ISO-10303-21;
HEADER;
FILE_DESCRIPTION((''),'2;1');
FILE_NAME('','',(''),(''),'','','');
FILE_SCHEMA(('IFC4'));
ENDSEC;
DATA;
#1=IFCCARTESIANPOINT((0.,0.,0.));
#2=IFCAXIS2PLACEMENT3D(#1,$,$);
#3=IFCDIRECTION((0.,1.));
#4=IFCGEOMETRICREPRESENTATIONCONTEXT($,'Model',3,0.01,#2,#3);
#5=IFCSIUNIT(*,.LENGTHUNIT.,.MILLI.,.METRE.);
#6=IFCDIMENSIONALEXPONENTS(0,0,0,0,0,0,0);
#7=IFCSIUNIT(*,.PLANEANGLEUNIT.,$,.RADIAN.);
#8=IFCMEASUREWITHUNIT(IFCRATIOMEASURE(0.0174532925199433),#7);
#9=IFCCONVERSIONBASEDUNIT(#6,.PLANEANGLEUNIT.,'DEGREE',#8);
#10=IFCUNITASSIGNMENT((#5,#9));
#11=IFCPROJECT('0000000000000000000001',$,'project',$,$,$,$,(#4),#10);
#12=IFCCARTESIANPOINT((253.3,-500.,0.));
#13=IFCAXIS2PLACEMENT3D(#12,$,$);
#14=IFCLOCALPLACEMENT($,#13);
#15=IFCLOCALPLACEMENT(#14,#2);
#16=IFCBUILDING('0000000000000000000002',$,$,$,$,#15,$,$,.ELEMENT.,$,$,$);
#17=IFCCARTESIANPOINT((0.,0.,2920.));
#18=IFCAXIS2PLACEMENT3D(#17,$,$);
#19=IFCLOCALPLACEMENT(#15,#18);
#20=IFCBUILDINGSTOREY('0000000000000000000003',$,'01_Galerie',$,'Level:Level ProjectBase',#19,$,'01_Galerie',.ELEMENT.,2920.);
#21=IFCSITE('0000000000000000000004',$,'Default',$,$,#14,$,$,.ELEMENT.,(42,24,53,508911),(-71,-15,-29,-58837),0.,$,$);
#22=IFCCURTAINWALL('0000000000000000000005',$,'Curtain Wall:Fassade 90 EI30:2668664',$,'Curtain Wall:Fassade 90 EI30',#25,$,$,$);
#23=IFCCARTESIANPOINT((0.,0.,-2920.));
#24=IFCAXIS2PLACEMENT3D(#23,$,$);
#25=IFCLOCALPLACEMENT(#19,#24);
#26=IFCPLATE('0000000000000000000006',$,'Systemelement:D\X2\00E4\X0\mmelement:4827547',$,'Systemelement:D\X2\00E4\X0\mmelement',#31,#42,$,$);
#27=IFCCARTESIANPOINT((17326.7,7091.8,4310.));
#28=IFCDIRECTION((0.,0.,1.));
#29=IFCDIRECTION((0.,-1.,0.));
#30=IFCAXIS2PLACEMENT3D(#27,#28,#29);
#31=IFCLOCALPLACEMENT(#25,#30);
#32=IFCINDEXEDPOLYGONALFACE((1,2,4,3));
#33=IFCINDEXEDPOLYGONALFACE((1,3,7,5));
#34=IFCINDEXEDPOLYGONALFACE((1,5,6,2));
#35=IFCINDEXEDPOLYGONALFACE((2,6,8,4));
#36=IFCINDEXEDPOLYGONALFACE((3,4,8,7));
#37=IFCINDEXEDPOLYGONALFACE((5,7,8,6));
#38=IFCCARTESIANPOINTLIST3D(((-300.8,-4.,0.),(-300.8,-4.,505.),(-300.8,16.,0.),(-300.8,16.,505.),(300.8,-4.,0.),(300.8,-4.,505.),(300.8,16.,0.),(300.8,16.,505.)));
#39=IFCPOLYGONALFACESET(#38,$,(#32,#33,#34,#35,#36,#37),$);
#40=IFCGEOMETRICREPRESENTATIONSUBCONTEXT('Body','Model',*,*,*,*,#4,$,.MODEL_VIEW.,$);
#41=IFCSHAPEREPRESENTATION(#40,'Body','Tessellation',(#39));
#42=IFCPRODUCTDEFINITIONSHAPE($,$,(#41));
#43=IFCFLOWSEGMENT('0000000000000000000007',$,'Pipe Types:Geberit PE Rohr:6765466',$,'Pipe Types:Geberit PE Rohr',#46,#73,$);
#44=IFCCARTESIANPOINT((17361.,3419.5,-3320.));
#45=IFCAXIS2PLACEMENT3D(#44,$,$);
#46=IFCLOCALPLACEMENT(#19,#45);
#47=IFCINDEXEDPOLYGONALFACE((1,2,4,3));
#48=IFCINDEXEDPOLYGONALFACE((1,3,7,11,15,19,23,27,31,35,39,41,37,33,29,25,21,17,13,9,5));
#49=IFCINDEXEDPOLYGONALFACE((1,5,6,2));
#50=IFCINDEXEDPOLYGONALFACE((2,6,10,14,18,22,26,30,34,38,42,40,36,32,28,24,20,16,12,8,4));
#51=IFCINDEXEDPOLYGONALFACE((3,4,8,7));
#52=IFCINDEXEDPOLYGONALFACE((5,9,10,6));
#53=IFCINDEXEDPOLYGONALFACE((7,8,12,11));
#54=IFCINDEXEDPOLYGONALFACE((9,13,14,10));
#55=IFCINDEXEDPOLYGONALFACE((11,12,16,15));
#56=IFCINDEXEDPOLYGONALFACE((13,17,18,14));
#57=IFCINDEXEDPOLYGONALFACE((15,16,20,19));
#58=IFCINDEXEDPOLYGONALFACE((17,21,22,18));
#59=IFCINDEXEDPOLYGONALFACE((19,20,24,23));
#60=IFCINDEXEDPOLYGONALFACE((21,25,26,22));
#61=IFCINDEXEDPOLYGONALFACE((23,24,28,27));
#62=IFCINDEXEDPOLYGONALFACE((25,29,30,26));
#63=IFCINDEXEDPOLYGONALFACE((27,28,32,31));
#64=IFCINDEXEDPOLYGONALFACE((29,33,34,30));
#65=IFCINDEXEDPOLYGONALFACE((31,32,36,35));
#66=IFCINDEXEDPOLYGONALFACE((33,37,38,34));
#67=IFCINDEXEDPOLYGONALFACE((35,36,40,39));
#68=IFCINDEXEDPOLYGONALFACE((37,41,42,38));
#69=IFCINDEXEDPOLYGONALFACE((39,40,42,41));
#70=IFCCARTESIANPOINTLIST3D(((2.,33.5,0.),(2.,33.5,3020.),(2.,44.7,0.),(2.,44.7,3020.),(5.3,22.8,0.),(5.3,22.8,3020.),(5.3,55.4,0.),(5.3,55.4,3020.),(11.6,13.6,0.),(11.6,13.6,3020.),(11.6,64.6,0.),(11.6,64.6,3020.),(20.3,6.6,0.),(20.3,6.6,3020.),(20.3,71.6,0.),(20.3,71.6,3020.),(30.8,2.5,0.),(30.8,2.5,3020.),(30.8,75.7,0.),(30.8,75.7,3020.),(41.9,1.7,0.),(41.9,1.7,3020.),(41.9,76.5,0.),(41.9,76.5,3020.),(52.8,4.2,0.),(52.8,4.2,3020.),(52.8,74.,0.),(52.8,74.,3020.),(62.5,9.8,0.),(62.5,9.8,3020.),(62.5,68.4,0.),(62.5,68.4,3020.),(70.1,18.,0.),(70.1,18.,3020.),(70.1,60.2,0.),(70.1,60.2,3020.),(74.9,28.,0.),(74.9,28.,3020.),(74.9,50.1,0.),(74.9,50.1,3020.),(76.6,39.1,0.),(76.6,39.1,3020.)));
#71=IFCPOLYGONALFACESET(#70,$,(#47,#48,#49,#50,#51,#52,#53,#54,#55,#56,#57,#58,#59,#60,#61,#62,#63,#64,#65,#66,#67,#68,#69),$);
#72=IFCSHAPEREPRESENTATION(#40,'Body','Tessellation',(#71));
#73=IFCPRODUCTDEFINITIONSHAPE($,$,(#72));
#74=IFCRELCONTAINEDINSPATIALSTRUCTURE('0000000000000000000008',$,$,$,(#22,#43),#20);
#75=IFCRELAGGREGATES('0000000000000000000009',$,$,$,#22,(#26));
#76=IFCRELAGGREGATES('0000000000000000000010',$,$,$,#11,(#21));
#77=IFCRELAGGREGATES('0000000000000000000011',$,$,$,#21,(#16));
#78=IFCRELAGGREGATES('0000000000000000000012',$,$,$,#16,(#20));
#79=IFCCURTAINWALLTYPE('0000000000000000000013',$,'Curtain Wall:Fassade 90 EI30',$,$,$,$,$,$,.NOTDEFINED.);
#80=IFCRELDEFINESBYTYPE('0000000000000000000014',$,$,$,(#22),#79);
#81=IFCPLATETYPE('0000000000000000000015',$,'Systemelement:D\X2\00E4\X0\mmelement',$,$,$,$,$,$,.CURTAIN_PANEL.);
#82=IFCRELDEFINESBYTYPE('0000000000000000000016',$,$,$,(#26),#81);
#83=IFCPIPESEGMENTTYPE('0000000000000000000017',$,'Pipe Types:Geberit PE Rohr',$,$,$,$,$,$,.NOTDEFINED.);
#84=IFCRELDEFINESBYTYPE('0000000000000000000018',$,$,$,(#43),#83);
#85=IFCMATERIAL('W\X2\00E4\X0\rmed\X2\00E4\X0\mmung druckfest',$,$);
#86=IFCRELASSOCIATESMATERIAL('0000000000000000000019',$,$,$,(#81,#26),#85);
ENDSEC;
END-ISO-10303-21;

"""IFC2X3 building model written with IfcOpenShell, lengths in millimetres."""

from ifc_helpers import new_model, entity, si_unit, converted_unit, direction, frame, origin, origin_2d_with_axis, place, context, subcontext, project, spatial, rectangle, circle, extrude, source, transform, mapped, material, type_object, type_shapes, element, aggregate, save


model = new_model("IFC2X3")

# Units and contexts
model_context = context("Model", 3, precision=0.01, world=origin(), true_north=direction((0.0, 1.0)))
body_context = subcontext(model_context, "Body", "Model", "MODEL_VIEW")
ifc_project = project(units=[si_unit("LENGTHUNIT", "METRE", prefix="MILLI"), converted_unit("PLANEANGLEUNIT", "DEGREE", entity("IfcRatioMeasure", 0.0174532925199433), si_unit("PLANEANGLEUNIT", "RADIAN"), dimensions=[0, 0, 0, 0, 0, 0, 0])], contexts=[model_context])

# Site, building, storey
site_placement = place(None, frame((253.3, -500.0, 0.0)))
site = spatial("IfcSite", under=ifc_project, at=site_placement, Name="Default", CompositionType="ELEMENT", RefLatitude=(42, 24, 53, 508911), RefLongitude=(-71, -15, -29, -58837), RefElevation=0.0)
building_placement = place(site_placement, origin())
building = spatial("IfcBuilding", under=site, at=building_placement, CompositionType="ELEMENT")
storey_placement = place(building_placement, frame((0.0, 0.0, 2920.0)))
storey = spatial("IfcBuildingStorey", under=building, at=storey_placement, Name="01_Galerie", ObjectType="Level:Level ProjectBase", LongName="01_Galerie", CompositionType="ELEMENT", Elevation=2920.0)

# Curtain wall, plate
curtain_wall_type = type_object("IfcCurtainWallType", Name="Curtain Wall:Fassade 90 EI30", PredefinedType="NOTDEFINED")
curtain_wall_placement = place(storey_placement, frame((0.0, 0.0, -2920.0)))
curtain_wall = element("IfcCurtainWall", 1, at=curtain_wall_placement, inside=storey, type_object=curtain_wall_type, Name="Curtain Wall:Fassade 90 EI30:2668664", ObjectType="Curtain Wall:Fassade 90 EI30")
ifc_material_1 = material(Name="Wärmedämmung druckfest")
plate_type = type_object("IfcPlateType", Name="Systemelement:Dämmelement", PredefinedType="CURTAIN_PANEL", material=ifc_material_1)
shared_shape_1 = source(origin(), body_context, "Body", "SweptSolid", [
    extrude(rectangle(XDim=20.0, YDim=601.6, at=origin_2d_with_axis()), frame((0.0, 6.0, 0.0), z_axis=(0.0, 0.0, 1.0), x_axis=(0.0, 1.0, 0.0)), (0.0, 0.0, 1.0), 505.0),
])
type_shapes(plate_type, [shared_shape_1])
plate_placement = place(curtain_wall_placement, frame((17326.7, 7091.8, 4310.0), z_axis=(0.0, 0.0, 1.0), x_axis=(0.0, -1.0, 0.0)))
plate = element("IfcPlate", 2, at=plate_placement, type_object=plate_type, material=ifc_material_1, Name="Systemelement:Dämmelement:4827547", ObjectType="Systemelement:Dämmelement", context=body_context, shape_type="MappedRepresentation", body=[
    mapped(shared_shape_1, transform((0.0, 0.0, 0.0), scale=1.0)),
])
aggregate(curtain_wall, [plate])

# Flow segment
pipe_segment_type = type_object("IfcPipeSegmentType", Name="Pipe Types:Geberit PE Rohr", PredefinedType="NOTDEFINED")
flow_segment_placement = place(storey_placement, frame((17361.0, 3419.5, -3320.0)))
element("IfcFlowSegment", 3, at=flow_segment_placement, inside=storey, type_object=pipe_segment_type, Name="Pipe Types:Geberit PE Rohr:6765466", ObjectType="Pipe Types:Geberit PE Rohr", context=body_context, shape_type="SweptSolid", body=[
    extrude(circle(Radius=37.5, at=origin_2d_with_axis()), frame((39.1, 39.1, 0.0)), (0.0, 0.0, 1.0), 3020.0),
])

save(model, "model.ifc")
